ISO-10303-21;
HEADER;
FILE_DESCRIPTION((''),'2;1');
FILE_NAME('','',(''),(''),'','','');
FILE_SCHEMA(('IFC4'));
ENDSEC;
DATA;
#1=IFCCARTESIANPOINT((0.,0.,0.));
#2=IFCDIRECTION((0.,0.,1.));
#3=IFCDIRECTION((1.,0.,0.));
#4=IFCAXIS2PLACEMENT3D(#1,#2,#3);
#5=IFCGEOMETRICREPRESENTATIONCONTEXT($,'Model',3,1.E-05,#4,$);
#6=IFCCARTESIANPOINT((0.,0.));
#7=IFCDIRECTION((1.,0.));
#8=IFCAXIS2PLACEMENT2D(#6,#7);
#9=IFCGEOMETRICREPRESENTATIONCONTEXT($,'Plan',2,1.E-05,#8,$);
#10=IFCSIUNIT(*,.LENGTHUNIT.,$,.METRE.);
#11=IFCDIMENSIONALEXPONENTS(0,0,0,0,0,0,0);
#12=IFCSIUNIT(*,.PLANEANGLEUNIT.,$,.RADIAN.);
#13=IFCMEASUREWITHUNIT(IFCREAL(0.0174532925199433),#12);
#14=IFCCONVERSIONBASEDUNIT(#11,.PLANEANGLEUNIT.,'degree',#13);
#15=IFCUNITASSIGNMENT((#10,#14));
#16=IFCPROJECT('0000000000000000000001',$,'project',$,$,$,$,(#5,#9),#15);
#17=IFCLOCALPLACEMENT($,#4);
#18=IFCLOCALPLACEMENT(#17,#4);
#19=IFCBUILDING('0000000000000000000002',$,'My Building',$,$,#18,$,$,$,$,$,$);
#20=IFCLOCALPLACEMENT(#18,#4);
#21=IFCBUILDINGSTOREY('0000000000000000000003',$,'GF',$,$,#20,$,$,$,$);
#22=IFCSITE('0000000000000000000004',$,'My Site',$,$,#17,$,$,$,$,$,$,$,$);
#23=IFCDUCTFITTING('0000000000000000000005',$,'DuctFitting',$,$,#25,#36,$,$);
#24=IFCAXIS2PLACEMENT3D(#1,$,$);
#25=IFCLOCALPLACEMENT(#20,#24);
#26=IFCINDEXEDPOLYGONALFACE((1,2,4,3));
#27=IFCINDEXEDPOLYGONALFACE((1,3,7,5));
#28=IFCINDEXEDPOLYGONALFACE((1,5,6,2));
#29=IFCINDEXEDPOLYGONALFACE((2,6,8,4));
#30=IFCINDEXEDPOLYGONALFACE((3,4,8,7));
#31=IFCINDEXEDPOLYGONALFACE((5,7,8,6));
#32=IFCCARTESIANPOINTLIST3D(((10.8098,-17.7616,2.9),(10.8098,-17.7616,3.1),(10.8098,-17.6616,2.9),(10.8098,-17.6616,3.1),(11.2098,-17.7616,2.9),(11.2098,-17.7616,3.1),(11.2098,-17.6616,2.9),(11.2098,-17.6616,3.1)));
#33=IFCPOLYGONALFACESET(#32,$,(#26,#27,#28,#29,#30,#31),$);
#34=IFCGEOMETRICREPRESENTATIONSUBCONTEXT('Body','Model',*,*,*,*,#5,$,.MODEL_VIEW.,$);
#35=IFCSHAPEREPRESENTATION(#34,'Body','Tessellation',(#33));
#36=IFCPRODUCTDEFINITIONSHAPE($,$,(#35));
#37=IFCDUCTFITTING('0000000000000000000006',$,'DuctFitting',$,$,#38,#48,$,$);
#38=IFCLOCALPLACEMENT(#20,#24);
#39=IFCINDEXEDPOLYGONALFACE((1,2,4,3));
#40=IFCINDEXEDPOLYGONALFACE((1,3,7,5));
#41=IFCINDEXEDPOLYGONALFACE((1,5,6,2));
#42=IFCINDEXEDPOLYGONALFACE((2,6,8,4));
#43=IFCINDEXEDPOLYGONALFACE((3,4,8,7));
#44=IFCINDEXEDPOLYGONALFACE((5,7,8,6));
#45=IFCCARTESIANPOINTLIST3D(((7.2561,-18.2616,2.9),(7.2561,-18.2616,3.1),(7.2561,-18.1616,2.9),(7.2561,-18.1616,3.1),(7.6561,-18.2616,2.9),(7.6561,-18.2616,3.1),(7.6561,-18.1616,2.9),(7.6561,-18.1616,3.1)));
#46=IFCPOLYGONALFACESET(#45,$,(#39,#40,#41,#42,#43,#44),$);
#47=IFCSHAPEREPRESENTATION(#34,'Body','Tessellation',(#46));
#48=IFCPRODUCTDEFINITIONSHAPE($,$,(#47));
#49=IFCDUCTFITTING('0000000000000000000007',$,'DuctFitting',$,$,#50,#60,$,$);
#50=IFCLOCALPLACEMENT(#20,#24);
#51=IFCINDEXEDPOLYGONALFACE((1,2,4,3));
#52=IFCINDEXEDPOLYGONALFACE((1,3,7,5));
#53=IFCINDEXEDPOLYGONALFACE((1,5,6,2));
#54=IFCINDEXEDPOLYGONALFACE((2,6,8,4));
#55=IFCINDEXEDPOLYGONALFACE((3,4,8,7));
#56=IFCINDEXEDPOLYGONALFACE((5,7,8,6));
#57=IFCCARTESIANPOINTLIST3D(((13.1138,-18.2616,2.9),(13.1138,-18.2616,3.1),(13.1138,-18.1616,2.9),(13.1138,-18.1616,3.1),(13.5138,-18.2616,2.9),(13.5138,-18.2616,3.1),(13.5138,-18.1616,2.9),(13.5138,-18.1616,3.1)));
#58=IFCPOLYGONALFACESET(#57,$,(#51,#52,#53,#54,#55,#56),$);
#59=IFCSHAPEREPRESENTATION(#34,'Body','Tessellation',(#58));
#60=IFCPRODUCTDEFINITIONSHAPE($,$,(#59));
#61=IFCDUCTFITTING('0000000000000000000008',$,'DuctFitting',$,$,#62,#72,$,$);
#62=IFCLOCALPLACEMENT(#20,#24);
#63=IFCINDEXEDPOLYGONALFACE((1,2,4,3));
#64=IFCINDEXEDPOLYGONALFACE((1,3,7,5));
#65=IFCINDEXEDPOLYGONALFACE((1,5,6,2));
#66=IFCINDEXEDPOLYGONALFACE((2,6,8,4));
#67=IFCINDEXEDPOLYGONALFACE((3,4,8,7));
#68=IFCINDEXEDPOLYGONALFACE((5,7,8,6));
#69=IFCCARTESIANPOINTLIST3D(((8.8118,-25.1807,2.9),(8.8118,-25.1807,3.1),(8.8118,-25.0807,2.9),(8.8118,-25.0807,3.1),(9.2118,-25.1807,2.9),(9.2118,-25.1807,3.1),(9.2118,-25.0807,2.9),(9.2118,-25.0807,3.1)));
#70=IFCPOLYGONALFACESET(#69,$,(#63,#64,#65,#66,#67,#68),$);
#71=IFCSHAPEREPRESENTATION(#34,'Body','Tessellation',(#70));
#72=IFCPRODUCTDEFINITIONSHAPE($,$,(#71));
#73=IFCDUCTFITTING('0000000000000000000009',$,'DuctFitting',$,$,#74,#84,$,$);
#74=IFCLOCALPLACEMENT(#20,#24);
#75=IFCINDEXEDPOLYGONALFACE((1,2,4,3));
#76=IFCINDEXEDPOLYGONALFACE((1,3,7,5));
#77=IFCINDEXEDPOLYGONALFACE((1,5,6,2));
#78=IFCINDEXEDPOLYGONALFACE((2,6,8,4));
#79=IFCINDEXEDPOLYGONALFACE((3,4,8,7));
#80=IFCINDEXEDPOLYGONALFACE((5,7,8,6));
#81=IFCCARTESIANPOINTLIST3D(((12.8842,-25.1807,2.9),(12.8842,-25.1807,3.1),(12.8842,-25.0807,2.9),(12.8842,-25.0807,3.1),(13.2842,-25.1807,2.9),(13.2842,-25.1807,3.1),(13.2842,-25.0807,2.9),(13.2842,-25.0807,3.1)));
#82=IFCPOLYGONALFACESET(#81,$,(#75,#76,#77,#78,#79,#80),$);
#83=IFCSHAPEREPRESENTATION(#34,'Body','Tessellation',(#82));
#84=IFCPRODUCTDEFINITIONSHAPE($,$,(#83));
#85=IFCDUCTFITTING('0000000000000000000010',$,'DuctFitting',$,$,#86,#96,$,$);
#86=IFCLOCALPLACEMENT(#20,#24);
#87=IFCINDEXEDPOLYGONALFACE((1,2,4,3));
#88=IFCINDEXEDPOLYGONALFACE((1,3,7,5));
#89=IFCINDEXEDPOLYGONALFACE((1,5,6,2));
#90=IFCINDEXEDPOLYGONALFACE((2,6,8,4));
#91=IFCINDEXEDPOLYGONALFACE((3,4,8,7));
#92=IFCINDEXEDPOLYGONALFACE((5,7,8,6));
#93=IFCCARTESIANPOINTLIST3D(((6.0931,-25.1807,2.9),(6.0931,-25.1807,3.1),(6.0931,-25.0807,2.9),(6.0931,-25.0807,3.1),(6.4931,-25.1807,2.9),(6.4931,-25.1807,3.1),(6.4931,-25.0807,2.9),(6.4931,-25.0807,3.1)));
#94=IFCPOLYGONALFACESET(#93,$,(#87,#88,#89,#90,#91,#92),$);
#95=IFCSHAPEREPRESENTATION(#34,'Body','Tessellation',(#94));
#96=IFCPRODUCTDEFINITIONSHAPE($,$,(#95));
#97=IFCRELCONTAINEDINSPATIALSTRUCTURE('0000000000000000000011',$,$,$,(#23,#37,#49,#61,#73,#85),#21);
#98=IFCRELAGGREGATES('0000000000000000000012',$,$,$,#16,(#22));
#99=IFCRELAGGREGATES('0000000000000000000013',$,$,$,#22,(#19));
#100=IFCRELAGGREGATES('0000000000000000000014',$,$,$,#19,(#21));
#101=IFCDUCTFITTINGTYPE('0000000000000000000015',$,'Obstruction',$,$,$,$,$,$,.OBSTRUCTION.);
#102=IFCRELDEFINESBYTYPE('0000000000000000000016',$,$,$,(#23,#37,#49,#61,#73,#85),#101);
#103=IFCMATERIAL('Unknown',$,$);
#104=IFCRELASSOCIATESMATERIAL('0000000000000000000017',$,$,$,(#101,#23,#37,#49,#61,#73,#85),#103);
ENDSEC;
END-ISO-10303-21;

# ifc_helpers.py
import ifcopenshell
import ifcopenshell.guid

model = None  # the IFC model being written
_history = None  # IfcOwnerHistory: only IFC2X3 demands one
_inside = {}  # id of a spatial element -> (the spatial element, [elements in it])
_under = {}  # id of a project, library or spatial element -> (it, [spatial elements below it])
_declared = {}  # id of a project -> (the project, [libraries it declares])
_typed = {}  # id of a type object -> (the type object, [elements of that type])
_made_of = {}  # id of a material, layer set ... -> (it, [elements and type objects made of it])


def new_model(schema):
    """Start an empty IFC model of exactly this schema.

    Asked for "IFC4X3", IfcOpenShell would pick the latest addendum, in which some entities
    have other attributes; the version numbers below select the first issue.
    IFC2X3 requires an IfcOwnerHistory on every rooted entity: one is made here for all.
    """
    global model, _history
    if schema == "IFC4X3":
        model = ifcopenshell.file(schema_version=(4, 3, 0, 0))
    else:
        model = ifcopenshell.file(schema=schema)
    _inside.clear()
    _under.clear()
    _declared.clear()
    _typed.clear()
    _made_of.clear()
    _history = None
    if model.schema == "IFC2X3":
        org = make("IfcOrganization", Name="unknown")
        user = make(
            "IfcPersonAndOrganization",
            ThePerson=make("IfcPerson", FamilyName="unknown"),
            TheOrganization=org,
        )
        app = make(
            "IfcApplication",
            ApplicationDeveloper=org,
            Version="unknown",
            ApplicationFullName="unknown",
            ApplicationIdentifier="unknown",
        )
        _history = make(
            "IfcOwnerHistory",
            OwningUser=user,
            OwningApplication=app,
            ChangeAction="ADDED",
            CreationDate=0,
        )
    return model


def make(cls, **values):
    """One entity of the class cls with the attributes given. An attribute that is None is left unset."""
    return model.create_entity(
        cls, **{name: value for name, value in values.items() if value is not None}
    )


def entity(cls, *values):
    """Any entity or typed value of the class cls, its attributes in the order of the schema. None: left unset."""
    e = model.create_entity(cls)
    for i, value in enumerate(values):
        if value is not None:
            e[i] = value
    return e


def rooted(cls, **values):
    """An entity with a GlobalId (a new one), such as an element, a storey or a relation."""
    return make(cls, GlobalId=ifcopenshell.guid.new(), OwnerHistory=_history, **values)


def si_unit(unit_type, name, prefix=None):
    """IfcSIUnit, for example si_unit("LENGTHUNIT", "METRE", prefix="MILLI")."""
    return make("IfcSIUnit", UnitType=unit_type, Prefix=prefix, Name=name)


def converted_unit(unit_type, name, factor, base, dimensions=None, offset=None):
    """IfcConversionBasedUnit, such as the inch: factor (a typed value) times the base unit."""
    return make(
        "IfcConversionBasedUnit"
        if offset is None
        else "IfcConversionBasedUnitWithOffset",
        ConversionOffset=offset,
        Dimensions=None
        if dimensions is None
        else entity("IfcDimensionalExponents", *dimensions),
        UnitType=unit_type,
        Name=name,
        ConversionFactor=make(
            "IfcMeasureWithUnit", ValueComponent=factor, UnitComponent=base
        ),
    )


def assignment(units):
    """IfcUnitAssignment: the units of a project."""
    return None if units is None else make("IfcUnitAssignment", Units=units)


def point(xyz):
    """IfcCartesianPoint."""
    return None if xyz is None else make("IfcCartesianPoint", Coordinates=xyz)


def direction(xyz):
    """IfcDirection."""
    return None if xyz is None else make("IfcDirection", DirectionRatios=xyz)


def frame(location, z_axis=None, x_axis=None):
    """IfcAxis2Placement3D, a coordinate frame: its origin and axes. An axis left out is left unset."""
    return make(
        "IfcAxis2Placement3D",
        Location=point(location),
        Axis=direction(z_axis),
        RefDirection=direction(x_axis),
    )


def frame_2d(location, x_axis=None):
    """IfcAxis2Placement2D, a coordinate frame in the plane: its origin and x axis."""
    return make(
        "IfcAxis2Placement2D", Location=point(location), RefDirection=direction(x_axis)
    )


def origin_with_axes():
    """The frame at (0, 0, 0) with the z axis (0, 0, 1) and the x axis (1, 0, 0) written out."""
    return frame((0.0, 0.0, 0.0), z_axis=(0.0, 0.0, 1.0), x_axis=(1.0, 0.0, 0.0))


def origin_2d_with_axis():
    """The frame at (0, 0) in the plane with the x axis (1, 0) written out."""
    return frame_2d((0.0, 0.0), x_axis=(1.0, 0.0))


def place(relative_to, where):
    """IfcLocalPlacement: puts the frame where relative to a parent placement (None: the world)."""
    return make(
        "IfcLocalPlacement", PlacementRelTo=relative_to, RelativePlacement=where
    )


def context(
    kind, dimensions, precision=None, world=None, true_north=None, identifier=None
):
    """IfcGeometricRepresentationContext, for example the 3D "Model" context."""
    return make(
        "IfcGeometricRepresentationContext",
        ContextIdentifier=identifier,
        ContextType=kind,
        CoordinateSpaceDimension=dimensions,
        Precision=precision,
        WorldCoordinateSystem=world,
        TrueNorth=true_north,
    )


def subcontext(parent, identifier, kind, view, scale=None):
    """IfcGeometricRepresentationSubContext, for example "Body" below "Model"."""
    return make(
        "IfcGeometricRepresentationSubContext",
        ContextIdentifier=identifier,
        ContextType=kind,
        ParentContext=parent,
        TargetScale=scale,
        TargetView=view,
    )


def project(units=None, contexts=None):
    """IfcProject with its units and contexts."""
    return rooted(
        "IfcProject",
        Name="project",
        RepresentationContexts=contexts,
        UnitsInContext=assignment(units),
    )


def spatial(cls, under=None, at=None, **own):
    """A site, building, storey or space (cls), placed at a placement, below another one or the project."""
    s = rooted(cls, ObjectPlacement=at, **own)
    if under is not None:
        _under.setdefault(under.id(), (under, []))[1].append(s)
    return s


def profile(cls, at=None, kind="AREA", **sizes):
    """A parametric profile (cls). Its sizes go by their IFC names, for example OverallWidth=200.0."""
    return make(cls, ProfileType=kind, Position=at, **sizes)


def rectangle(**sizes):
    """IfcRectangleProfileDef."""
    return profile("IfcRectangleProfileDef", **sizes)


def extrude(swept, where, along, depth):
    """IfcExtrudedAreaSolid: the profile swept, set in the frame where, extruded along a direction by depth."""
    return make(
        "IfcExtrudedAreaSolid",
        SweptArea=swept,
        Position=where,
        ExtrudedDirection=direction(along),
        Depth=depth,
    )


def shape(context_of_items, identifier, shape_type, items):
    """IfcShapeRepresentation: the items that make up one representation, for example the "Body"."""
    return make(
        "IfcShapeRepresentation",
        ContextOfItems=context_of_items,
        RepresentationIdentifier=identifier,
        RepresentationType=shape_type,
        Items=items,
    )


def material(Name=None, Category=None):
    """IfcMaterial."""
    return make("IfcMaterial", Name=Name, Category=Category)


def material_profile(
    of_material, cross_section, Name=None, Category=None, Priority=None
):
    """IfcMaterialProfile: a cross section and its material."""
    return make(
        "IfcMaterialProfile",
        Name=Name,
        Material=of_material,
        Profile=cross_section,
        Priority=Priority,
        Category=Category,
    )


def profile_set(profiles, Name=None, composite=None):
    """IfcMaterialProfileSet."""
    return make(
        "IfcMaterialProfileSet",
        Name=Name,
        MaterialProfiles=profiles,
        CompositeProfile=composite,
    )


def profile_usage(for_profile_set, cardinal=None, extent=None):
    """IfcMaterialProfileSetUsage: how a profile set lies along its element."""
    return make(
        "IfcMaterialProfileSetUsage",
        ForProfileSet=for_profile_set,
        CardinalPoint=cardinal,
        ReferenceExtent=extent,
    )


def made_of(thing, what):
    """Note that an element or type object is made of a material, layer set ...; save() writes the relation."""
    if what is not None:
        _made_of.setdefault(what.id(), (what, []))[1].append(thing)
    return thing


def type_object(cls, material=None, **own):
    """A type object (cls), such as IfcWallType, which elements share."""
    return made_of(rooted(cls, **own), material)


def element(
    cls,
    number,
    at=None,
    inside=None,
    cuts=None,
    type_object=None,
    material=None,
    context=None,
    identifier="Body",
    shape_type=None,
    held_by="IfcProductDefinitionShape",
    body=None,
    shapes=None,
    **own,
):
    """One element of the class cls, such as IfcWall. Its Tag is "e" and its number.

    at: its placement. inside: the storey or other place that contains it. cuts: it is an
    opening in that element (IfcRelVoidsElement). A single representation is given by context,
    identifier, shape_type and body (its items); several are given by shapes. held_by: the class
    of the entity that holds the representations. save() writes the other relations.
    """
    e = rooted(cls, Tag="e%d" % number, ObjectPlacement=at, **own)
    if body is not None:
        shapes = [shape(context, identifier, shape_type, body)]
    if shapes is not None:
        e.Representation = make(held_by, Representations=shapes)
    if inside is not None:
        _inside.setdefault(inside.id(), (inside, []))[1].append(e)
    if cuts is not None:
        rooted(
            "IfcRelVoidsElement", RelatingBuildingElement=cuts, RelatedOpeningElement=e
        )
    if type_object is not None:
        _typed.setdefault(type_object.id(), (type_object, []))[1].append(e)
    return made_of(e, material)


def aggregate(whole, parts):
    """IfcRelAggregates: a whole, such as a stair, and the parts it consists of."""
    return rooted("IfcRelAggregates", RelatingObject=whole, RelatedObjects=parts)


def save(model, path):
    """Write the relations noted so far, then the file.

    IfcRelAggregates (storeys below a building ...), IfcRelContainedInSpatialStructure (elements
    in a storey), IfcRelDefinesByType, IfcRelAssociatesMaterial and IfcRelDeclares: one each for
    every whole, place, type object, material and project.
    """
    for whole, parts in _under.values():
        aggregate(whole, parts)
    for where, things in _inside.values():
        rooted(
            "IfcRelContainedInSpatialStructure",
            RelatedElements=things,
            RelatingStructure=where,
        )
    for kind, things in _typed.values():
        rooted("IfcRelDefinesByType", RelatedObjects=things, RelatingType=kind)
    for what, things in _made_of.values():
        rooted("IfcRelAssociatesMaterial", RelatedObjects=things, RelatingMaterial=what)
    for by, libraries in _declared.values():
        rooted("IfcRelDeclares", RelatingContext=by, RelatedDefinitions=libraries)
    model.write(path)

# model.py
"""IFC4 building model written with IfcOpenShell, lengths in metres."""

from ifc_helpers import new_model, entity, si_unit, converted_unit, frame, origin_with_axes, origin_2d_with_axis, place, context, subcontext, project, spatial, rectangle, extrude, material, material_profile, profile_set, profile_usage, type_object, element, save


model = new_model("IFC4")

# Units and contexts
model_context = context("Model", 3, precision=1e-05, world=origin_with_axes())
plan_context = context("Plan", 2, precision=1e-05, world=origin_2d_with_axis())
body_context_1 = subcontext(model_context, "Body", "Model", "MODEL_VIEW")
ifc_project = project(units=[si_unit("LENGTHUNIT", "METRE"), converted_unit("PLANEANGLEUNIT", "degree", entity("IfcReal", 0.0174532925199433), si_unit("PLANEANGLEUNIT", "RADIAN"), dimensions=[0, 0, 0, 0, 0, 0, 0])], contexts=[model_context, plan_context])

# Site, building, storey
site_placement = place(None, origin_with_axes())
site = spatial("IfcSite", under=ifc_project, at=site_placement, Name="My Site")
building_placement = place(site_placement, origin_with_axes())
building = spatial("IfcBuilding", under=site, at=building_placement, Name="My Building")
storey_placement = place(building_placement, origin_with_axes())
storey = spatial("IfcBuildingStorey", under=building, at=storey_placement, Name="GF")

# Shared definitions
ifc_material = material(Name="Unknown")

# Duct fittings
ifc_material_profile = material_profile(ifc_material, rectangle(XDim=0.4, YDim=0.2))
ifc_profile_set = profile_set([ifc_material_profile])
duct_fitting_type = type_object("IfcDuctFittingType", Name="Obstruction", PredefinedType="OBSTRUCTION", material=ifc_profile_set)
ifc_profile_usage_1 = profile_usage(ifc_profile_set, cardinal=5)
duct_fitting_1_placement = place(storey_placement, frame((11.0098, -17.7616, 3.0), z_axis=(0.0, 1.0, 0.0), x_axis=(-1.0, 0.0, 0.0)))
element("IfcDuctFitting", 1, at=duct_fitting_1_placement, inside=storey, type_object=duct_fitting_type, material=ifc_profile_usage_1, Name="DuctFitting", context=body_context_1, shape_type="SweptSolid", body=[
    extrude(rectangle(XDim=0.4, YDim=0.2), origin_with_axes(), (0.0, 0.0, 1.0), 0.1),
])
ifc_profile_usage_2 = profile_usage(ifc_profile_set, cardinal=5)
duct_fitting_2_placement = place(storey_placement, frame((7.4561, -18.1616, 3.0), z_axis=(0.0, -1.0, 0.0), x_axis=(1.0, 0.0, 0.0)))
element("IfcDuctFitting", 2, at=duct_fitting_2_placement, inside=storey, type_object=duct_fitting_type, material=ifc_profile_usage_2, Name="DuctFitting", context=body_context_1, shape_type="SweptSolid", body=[
    extrude(rectangle(XDim=0.4, YDim=0.2), origin_with_axes(), (0.0, 0.0, 1.0), 0.1),
])
ifc_profile_usage_3 = profile_usage(ifc_profile_set, cardinal=5)
duct_fitting_3_placement = place(storey_placement, frame((13.3138, -18.1616, 3.0), z_axis=(0.0, -1.0, 0.0), x_axis=(1.0, 0.0, 0.0)))
element("IfcDuctFitting", 3, at=duct_fitting_3_placement, inside=storey, type_object=duct_fitting_type, material=ifc_profile_usage_3, Name="DuctFitting", context=body_context_1, shape_type="SweptSolid", body=[
    extrude(rectangle(XDim=0.4, YDim=0.2), origin_with_axes(), (0.0, 0.0, 1.0), 0.1),
])
ifc_profile_usage_4 = profile_usage(ifc_profile_set, cardinal=5)
duct_fitting_4_placement = place(storey_placement, frame((9.0118, -25.0807, 3.0), z_axis=(0.0, -1.0, 0.0), x_axis=(1.0, 0.0, 0.0)))
element("IfcDuctFitting", 4, at=duct_fitting_4_placement, inside=storey, type_object=duct_fitting_type, material=ifc_profile_usage_4, Name="DuctFitting", context=body_context_1, shape_type="SweptSolid", body=[
    extrude(rectangle(XDim=0.4, YDim=0.2), origin_with_axes(), (0.0, 0.0, 1.0), 0.1),
])
ifc_profile_usage_5 = profile_usage(ifc_profile_set, cardinal=5)
duct_fitting_5_placement = place(storey_placement, frame((13.0842, -25.0807, 3.0), z_axis=(0.0, -1.0, 0.0), x_axis=(1.0, 0.0, 0.0)))
element("IfcDuctFitting", 5, at=duct_fitting_5_placement, inside=storey, type_object=duct_fitting_type, material=ifc_profile_usage_5, Name="DuctFitting", context=body_context_1, shape_type="SweptSolid", body=[
    extrude(rectangle(XDim=0.4, YDim=0.2), origin_with_axes(), (0.0, 0.0, 1.0), 0.1),
])
ifc_profile_usage_6 = profile_usage(ifc_profile_set, cardinal=5)
duct_fitting_6_placement = place(storey_placement, frame((6.2931, -25.0807, 3.0), z_axis=(0.0, -1.0, 0.0), x_axis=(1.0, 0.0, 0.0)))
element("IfcDuctFitting", 6, at=duct_fitting_6_placement, inside=storey, type_object=duct_fitting_type, material=ifc_profile_usage_6, Name="DuctFitting", context=body_context_1, shape_type="SweptSolid", body=[
    extrude(rectangle(XDim=0.4, YDim=0.2), origin_with_axes(), (0.0, 0.0, 1.0), 0.1),
])

save(model, "model.ifc")
